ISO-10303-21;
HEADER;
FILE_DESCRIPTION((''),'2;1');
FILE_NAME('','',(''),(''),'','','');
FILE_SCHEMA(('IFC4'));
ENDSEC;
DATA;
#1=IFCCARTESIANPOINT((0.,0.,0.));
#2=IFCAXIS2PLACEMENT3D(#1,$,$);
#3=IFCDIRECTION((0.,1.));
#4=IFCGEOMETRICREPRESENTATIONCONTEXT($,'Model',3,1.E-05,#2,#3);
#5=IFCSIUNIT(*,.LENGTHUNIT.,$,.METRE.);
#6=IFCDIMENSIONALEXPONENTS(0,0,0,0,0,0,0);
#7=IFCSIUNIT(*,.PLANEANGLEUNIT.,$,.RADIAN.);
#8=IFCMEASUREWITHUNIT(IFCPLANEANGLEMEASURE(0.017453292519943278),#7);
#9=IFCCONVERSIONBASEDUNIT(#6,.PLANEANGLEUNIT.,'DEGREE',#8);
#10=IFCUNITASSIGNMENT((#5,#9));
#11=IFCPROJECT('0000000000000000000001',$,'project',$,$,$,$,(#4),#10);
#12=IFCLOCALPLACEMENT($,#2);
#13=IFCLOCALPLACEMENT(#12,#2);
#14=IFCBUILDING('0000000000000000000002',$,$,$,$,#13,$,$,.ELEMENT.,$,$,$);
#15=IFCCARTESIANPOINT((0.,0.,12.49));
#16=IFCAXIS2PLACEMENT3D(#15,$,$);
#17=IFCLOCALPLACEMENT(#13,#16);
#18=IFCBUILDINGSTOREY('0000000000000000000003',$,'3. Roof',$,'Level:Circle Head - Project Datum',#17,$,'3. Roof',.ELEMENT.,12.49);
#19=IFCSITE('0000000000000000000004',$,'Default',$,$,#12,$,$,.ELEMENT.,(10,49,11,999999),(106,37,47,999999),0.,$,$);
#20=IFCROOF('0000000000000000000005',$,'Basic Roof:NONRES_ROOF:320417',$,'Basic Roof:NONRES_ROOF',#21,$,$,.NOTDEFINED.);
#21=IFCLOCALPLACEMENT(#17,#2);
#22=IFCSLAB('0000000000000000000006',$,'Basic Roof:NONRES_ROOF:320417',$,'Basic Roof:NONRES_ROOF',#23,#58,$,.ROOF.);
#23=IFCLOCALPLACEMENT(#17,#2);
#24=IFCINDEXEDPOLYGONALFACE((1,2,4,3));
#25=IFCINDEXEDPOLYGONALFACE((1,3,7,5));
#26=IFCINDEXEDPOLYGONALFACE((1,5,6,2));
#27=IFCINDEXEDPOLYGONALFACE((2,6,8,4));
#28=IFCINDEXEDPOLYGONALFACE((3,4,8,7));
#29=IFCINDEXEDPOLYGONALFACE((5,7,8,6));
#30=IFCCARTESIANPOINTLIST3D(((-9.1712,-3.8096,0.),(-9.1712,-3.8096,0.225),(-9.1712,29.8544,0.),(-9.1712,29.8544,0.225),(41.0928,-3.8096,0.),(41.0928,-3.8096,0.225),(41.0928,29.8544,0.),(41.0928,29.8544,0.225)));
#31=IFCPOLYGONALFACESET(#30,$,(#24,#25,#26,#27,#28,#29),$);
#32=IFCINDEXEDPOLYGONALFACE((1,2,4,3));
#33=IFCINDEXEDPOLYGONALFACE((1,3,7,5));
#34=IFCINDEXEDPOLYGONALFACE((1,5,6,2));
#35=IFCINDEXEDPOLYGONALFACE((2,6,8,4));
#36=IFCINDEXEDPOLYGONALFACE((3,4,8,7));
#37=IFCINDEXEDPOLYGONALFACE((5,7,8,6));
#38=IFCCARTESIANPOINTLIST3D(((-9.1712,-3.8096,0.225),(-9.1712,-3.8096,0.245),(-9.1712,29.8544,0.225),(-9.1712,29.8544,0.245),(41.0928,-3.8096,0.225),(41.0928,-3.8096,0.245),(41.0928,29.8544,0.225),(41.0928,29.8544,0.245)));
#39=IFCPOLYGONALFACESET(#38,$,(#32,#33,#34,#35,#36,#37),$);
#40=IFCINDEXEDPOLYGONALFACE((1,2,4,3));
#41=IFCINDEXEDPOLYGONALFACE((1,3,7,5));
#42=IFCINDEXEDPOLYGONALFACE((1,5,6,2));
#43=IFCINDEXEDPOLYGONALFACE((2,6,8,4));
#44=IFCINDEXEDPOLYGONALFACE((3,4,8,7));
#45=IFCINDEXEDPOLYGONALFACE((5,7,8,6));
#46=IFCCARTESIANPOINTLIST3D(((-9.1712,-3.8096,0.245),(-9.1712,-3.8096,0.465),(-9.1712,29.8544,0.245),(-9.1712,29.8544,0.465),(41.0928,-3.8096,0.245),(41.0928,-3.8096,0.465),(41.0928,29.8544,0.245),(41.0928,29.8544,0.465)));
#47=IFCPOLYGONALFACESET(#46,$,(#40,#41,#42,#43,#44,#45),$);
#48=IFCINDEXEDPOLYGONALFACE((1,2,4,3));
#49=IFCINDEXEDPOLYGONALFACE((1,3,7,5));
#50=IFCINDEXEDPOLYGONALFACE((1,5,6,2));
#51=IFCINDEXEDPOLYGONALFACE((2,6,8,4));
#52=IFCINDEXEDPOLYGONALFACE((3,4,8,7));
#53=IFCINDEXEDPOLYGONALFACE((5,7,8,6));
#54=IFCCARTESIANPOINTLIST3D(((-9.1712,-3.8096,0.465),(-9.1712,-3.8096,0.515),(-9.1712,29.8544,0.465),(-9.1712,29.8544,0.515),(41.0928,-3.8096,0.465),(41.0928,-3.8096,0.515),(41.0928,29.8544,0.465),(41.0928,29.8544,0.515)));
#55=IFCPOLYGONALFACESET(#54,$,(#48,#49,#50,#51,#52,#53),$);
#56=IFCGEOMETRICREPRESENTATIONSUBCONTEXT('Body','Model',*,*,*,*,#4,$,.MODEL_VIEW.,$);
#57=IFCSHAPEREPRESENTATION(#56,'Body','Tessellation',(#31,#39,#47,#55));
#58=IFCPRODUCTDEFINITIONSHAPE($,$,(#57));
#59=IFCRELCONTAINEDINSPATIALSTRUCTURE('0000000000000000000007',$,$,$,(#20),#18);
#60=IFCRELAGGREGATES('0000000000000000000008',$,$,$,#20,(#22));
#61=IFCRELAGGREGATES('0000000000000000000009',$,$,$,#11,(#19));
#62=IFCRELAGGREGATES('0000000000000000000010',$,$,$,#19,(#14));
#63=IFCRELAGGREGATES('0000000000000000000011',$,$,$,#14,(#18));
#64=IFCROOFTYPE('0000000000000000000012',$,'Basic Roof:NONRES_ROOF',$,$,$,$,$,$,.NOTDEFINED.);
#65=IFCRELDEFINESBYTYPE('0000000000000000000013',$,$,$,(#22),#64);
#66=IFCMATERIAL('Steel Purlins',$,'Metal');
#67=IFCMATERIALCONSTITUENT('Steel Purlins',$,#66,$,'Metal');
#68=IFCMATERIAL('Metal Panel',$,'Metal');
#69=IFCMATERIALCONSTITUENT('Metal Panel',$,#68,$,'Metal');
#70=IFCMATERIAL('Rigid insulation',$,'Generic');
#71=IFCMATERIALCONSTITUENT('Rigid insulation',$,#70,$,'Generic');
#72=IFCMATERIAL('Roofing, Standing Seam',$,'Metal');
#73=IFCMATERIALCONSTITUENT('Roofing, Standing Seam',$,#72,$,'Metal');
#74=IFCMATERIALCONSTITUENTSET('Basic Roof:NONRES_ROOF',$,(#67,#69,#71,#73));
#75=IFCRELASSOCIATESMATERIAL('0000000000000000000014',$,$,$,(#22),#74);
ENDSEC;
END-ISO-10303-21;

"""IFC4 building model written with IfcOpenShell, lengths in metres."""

from ifc_helpers import new_model, entity, si_unit, converted_unit, direction, frame, origin, place, context, subcontext, project, spatial, indexed_curve, outline, extrude, material, constituent, constituent_set, type_object, element, aggregate, save


model = new_model("IFC4")

# Units and contexts
model_context = context("Model", 3, precision=1e-05, world=origin(), true_north=direction((0.0, 1.0)))
body_context = subcontext(model_context, "Body", "Model", "MODEL_VIEW")
ifc_project = project(units=[si_unit("LENGTHUNIT", "METRE"), converted_unit("PLANEANGLEUNIT", "DEGREE", entity("IfcPlaneAngleMeasure", 0.017453292519943278), si_unit("PLANEANGLEUNIT", "RADIAN"), dimensions=[0, 0, 0, 0, 0, 0, 0])], contexts=[model_context])

# Site, building, storey
site_placement = place(None, origin())
site = spatial("IfcSite", under=ifc_project, at=site_placement, Name="Default", CompositionType="ELEMENT", RefLatitude=(10, 49, 11, 999999), RefLongitude=(106, 37, 47, 999999), RefElevation=0.0)
building_placement = place(site_placement, origin())
building = spatial("IfcBuilding", under=site, at=building_placement, CompositionType="ELEMENT")
storey_placement = place(building_placement, frame((0.0, 0.0, 12.49)))
storey = spatial("IfcBuildingStorey", under=building, at=storey_placement, Name="3. Roof", ObjectType="Level:Circle Head - Project Datum", LongName="3. Roof", CompositionType="ELEMENT", Elevation=12.49)

# Roof, slab
roof_placement = place(storey_placement, frame((-9.1712, -3.8096, 0.0)))
roof = element("IfcRoof", 1, at=roof_placement, inside=storey, Name="Basic Roof:NONRES_ROOF:320417", ObjectType="Basic Roof:NONRES_ROOF", PredefinedType="NOTDEFINED")
ifc_material_1 = material(Name="Steel Purlins", Category="Metal")
ifc_constituent_1 = constituent(ifc_material_1, Name="Steel Purlins", Category="Metal")
ifc_material_2 = material(Name="Metal Panel", Category="Metal")
ifc_constituent_2 = constituent(ifc_material_2, Name="Metal Panel", Category="Metal")
ifc_material_3 = material(Name="Rigid insulation", Category="Generic")
ifc_constituent_3 = constituent(ifc_material_3, Name="Rigid insulation", Category="Generic")
ifc_material_4 = material(Name="Roofing, Standing Seam", Category="Metal")
ifc_constituent_4 = constituent(ifc_material_4, Name="Roofing, Standing Seam", Category="Metal")
ifc_constituent_set = constituent_set(constituents=[ifc_constituent_1, ifc_constituent_2, ifc_constituent_3, ifc_constituent_4], Name="Basic Roof:NONRES_ROOF")
roof_type = type_object("IfcRoofType", Name="Basic Roof:NONRES_ROOF", PredefinedType="NOTDEFINED")
slab_placement = place(roof_placement, origin())
slab = element("IfcSlab", 2, at=slab_placement, type_object=roof_type, material=ifc_constituent_set, Name="Basic Roof:NONRES_ROOF:320417", ObjectType="Basic Roof:NONRES_ROOF", PredefinedType="ROOF", context=body_context, shape_type="SweptSolid", body=[
    extrude(outline(indexed_curve([(-25.132, 16.832), (-25.132, -16.832), (25.132, -16.832), (25.132, 16.832), (-25.132, 16.832)], self_intersect=False)), frame((25.132, 16.832, 0.0)), (0.0, 0.0, 1.0), 0.225),
    extrude(outline(indexed_curve([(-25.132, 16.832), (-25.132, -16.832), (25.132, -16.832), (25.132, 16.832), (-25.132, 16.832)], self_intersect=False)), frame((25.132, 16.832, 0.225)), (0.0, 0.0, 1.0), 0.02),
    extrude(outline(indexed_curve([(-25.132, 16.832), (-25.132, -16.832), (25.132, -16.832), (25.132, 16.832), (-25.132, 16.832)], self_intersect=False)), frame((25.132, 16.832, 0.245)), (0.0, 0.0, 1.0), 0.22),
    extrude(outline(indexed_curve([(-25.132, 16.832), (-25.132, -16.832), (25.132, -16.832), (25.132, 16.832), (-25.132, 16.832)], self_intersect=False)), frame((25.132, 16.832, 0.465)), (0.0, 0.0, 1.0), 0.05),
])
aggregate(roof, [slab])

save(model, "model.ifc")
